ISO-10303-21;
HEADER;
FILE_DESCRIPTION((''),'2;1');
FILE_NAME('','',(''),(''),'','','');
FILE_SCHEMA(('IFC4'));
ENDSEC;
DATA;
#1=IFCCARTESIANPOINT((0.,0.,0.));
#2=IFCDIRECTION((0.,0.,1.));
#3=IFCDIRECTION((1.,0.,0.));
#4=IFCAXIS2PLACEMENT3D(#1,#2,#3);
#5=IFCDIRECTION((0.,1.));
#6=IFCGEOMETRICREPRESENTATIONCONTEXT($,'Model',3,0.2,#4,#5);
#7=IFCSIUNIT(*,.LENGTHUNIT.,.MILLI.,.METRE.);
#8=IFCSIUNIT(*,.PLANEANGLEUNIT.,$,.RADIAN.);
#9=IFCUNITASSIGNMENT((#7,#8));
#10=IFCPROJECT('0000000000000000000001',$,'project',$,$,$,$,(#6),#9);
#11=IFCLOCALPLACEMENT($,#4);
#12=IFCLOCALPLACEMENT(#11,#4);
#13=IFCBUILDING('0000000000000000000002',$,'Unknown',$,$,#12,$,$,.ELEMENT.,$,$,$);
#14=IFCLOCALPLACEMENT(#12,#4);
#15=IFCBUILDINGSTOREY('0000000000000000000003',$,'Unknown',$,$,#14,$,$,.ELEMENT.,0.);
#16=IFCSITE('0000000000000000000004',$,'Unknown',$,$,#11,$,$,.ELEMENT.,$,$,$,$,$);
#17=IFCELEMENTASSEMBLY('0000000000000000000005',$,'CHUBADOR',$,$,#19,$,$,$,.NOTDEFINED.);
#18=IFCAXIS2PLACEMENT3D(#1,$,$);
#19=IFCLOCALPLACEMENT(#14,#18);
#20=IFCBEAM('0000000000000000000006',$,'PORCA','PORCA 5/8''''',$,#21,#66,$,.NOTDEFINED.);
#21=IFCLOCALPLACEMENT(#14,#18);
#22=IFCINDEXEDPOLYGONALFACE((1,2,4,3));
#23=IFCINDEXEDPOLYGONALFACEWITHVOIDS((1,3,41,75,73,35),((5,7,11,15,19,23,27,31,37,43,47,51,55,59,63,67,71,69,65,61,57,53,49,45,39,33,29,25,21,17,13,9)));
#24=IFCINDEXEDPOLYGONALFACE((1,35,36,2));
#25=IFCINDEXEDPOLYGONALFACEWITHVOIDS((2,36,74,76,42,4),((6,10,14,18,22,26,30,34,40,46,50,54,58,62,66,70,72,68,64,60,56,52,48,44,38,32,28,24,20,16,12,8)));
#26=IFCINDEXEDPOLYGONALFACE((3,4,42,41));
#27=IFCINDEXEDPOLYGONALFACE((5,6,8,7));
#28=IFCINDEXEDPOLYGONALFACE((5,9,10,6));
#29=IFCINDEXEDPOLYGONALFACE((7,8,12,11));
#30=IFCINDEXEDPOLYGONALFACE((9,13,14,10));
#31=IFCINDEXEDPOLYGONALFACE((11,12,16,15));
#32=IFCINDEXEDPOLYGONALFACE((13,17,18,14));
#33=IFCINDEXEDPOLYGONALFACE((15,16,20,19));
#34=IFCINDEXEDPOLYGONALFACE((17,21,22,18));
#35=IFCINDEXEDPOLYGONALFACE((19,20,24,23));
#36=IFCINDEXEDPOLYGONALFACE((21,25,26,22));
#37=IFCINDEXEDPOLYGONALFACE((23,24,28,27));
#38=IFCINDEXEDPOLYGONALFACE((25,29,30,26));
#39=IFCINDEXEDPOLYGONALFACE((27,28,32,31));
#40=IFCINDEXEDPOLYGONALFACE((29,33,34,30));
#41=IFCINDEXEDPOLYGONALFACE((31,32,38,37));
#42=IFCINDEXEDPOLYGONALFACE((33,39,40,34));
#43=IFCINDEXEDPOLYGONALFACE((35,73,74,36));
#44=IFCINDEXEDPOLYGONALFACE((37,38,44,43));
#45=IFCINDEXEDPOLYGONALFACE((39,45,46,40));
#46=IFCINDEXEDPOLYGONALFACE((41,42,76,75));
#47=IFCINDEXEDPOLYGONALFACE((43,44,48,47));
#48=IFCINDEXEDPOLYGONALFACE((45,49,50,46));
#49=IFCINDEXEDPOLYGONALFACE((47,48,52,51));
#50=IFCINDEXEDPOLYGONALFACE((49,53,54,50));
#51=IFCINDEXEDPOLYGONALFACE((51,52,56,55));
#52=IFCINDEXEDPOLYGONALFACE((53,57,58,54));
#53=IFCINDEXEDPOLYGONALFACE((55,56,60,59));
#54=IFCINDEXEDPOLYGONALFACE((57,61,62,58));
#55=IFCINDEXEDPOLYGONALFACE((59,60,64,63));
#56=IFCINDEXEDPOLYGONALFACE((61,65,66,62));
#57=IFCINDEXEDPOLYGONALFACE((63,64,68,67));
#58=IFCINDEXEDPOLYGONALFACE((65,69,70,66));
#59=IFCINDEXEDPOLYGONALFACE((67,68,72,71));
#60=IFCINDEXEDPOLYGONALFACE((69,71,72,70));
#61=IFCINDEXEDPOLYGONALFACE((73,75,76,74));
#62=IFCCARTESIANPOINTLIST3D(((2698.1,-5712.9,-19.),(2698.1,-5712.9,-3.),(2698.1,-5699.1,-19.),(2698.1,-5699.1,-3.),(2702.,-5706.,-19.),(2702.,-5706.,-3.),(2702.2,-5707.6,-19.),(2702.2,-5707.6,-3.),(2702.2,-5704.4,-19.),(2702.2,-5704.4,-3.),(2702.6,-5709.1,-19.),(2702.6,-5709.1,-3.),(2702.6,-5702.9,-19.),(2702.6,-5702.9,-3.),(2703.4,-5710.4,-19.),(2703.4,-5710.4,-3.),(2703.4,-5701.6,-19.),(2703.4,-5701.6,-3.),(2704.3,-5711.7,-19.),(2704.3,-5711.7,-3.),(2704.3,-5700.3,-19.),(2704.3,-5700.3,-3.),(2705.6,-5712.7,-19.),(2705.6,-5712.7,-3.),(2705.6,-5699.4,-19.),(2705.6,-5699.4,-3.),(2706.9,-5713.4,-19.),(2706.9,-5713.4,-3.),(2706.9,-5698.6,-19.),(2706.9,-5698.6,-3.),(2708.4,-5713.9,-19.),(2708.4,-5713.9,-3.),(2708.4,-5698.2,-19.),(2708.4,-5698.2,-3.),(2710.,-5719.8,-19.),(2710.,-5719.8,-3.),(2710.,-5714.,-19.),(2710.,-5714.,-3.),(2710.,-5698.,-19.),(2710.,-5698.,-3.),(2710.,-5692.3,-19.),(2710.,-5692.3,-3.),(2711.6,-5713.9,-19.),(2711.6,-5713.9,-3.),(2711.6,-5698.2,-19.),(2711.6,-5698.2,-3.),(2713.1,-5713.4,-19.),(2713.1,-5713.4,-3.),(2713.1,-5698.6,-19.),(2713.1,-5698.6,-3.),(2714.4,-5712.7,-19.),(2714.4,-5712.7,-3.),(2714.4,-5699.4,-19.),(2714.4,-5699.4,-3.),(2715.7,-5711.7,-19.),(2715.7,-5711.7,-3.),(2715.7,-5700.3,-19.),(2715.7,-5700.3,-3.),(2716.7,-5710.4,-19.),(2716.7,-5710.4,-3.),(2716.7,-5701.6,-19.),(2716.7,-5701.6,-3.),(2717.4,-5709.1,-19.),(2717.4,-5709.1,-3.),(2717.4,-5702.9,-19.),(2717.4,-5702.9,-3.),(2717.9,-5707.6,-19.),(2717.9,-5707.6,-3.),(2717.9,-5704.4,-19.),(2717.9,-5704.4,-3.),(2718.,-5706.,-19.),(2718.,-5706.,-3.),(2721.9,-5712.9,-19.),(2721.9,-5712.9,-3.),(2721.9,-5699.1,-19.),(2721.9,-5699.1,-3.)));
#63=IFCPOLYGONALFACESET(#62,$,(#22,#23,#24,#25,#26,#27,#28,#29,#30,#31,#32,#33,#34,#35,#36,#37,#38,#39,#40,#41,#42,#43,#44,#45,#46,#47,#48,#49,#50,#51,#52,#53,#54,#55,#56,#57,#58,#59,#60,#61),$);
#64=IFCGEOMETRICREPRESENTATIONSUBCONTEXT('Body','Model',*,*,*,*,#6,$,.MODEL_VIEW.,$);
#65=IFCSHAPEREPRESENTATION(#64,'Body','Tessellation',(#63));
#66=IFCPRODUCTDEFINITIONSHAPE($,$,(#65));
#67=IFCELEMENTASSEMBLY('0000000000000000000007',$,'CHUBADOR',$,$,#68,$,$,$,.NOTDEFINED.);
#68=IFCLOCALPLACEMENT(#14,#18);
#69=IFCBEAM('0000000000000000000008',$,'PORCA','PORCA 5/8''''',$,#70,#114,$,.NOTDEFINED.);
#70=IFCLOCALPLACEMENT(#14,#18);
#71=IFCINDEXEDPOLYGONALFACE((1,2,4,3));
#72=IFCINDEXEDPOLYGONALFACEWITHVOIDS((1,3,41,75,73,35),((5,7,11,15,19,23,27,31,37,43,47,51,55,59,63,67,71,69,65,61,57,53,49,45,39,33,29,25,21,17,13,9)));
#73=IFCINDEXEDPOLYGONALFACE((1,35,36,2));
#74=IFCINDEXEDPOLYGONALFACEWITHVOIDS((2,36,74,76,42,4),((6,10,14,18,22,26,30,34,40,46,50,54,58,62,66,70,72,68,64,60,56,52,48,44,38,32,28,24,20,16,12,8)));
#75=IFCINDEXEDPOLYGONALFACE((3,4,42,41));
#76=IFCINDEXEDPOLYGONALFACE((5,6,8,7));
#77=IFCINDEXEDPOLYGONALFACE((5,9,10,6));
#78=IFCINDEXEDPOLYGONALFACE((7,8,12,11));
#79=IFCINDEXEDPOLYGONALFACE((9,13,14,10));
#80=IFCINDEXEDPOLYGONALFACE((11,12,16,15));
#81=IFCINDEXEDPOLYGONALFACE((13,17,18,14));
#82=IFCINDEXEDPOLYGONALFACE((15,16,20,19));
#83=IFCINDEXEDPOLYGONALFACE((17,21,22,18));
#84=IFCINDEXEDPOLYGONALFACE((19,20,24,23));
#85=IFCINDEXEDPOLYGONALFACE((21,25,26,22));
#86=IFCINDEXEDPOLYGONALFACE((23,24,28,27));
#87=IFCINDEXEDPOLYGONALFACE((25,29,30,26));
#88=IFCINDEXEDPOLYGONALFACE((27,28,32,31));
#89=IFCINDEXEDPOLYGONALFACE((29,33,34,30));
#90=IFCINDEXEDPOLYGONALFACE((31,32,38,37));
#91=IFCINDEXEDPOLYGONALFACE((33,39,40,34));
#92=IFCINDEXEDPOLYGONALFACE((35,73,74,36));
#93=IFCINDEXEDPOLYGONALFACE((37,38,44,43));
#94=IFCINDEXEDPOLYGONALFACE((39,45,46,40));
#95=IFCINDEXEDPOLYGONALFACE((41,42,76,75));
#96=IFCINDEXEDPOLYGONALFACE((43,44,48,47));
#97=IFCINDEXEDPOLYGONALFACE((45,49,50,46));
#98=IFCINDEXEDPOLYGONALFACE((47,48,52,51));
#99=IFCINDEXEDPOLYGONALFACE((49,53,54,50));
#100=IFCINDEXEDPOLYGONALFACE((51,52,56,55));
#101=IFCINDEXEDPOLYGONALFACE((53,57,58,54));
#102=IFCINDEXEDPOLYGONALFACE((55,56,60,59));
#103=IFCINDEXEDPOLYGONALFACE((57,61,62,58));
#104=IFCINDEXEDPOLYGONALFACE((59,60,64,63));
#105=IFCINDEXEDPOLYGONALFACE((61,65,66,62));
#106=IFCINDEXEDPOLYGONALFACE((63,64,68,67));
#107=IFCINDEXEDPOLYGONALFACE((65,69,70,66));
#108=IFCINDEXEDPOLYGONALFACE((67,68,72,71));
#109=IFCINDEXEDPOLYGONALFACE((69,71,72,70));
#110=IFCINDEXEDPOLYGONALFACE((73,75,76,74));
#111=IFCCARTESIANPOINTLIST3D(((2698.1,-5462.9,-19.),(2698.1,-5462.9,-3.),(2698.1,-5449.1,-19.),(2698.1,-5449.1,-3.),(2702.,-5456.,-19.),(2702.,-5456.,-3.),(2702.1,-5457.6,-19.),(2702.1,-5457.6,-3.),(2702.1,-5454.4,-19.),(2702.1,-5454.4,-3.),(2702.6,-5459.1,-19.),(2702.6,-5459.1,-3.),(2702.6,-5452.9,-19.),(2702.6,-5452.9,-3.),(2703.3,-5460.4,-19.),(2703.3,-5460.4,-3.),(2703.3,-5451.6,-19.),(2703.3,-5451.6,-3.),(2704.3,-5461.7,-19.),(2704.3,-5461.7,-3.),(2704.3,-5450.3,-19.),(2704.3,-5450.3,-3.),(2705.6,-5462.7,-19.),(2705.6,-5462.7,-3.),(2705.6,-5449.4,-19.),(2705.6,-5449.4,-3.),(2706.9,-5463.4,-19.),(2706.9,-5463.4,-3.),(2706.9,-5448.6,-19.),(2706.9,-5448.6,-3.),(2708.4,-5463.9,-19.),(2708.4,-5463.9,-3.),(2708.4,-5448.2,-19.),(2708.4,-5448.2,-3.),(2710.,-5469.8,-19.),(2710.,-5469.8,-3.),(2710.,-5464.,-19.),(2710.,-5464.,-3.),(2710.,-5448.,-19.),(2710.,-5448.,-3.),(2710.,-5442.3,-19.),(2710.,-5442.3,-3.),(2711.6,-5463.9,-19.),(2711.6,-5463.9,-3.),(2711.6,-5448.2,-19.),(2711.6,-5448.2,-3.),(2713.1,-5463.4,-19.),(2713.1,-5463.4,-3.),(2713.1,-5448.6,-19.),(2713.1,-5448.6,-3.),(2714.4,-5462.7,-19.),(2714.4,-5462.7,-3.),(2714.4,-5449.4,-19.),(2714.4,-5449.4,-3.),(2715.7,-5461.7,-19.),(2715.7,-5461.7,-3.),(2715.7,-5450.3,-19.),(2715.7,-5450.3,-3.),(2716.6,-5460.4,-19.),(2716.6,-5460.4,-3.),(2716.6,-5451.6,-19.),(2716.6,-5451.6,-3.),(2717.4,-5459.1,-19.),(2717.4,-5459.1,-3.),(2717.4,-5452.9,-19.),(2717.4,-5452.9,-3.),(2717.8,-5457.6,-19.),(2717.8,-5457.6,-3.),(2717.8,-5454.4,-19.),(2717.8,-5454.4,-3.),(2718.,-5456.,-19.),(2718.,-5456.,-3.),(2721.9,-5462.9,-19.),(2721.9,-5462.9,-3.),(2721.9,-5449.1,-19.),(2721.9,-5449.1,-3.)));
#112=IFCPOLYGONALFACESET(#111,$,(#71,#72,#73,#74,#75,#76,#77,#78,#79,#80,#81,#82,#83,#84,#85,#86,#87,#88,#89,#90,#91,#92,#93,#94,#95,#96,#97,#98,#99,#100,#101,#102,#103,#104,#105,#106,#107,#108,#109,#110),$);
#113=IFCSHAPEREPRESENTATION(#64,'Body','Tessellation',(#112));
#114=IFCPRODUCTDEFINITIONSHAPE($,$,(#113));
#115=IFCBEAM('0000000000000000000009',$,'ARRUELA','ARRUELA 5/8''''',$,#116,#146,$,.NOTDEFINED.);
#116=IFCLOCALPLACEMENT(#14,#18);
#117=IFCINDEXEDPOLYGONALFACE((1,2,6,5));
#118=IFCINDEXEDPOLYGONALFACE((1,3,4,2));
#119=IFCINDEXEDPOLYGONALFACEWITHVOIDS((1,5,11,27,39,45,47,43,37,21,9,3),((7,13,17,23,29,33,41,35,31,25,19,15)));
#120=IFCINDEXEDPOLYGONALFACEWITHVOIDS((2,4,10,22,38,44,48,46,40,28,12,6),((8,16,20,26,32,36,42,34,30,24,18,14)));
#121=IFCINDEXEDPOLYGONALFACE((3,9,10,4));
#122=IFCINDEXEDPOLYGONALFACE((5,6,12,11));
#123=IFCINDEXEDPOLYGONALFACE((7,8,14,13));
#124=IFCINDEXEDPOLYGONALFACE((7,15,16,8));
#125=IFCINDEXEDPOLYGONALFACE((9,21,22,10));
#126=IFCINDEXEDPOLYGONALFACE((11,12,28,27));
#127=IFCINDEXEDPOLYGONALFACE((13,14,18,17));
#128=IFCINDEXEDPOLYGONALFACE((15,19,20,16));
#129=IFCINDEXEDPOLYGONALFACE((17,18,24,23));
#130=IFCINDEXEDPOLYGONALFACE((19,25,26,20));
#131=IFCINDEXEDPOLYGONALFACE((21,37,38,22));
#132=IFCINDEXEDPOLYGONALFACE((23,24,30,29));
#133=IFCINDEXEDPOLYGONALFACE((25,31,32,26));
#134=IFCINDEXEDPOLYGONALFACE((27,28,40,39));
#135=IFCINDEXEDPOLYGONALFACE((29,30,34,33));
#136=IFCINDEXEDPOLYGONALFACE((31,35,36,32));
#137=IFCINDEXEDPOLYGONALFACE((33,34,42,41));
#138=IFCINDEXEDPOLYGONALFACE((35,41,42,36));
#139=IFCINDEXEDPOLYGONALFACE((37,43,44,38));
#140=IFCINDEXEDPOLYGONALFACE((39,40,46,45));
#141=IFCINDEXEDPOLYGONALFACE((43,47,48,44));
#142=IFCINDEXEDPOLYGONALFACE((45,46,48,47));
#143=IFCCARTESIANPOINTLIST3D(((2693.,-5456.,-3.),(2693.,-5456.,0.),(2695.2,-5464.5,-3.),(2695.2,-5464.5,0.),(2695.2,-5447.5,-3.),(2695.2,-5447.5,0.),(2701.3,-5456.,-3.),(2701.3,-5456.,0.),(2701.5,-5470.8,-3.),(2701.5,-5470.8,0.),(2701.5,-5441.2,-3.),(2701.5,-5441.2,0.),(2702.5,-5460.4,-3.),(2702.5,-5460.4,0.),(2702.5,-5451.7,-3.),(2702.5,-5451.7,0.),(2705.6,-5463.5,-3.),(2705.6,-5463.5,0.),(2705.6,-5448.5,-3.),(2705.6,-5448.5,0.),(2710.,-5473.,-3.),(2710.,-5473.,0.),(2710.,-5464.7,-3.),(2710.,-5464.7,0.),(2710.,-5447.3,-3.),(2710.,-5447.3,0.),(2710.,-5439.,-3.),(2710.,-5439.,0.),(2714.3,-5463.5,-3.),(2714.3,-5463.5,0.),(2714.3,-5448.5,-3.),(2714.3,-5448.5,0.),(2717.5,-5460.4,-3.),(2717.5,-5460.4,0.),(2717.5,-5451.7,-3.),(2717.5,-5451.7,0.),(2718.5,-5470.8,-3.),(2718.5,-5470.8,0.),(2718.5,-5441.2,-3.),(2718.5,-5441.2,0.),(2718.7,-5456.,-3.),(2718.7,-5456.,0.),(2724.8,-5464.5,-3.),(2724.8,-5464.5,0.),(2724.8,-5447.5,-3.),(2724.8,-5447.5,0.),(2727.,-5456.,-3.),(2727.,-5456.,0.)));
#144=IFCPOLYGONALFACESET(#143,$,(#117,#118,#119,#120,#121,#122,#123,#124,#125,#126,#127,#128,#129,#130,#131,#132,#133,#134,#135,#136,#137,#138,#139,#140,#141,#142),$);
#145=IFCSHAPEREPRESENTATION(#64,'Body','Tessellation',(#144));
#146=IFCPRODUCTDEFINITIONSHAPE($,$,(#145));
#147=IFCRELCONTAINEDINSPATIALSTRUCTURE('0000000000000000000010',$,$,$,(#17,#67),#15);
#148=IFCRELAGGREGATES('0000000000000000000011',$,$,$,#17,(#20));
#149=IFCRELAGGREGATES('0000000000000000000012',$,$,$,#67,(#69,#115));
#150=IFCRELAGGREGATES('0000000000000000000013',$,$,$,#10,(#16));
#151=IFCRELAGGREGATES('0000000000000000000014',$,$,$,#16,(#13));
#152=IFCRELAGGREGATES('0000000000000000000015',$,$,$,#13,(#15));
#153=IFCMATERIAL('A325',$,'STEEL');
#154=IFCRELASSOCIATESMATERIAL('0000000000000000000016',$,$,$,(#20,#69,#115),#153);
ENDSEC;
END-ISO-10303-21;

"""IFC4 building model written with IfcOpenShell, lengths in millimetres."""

from ifc_helpers import new_model, si_unit, direction, frame, origin_with_axes, place, context, subcontext, project, spatial, line, indexed_curve, outline, extrude, material, element, aggregate, save


model = new_model("IFC4")

# Units and contexts
model_context = context("Model", 3, precision=0.2, world=origin_with_axes(), true_north=direction((0.0, 1.0)))
body_context = subcontext(model_context, "Body", "Model", "MODEL_VIEW")
ifc_project = project(units=[si_unit("LENGTHUNIT", "METRE", prefix="MILLI"), si_unit("PLANEANGLEUNIT", "RADIAN")], contexts=[model_context])

# Site, building, storey
site_placement = place(None, origin_with_axes())
site = spatial("IfcSite", under=ifc_project, at=site_placement, Name="Unknown", CompositionType="ELEMENT")
building_placement = place(site_placement, origin_with_axes())
building = spatial("IfcBuilding", under=site, at=building_placement, Name="Unknown", CompositionType="ELEMENT")
storey_placement = place(building_placement, origin_with_axes())
storey = spatial("IfcBuildingStorey", under=building, at=storey_placement, Name="Unknown", CompositionType="ELEMENT", Elevation=0.0)

# Shared definitions
ifc_material_1 = material(Name="A325", Category="STEEL")

# Element assemblies, beams
assembly_1_placement = place(storey_placement, frame((2710.0, -5706.0, -52.1), z_axis=(-1.0, 0.0, 0.0), x_axis=(0.0, 0.0, -1.0)))
assembly_1 = element("IfcElementAssembly", 1, at=assembly_1_placement, inside=storey, Name="CHUBADOR", PredefinedType="NOTDEFINED")
beam_1_placement = place(assembly_1_placement, frame((-49.1, 0.0, 0.0), z_axis=(0.0, 0.0, 1.0), x_axis=(1.0, 0.0, 0.0)))
beam_1 = element("IfcBeam", 2, at=beam_1_placement, material=ifc_material_1, Name="PORCA", Description="PORCA 5/8''", PredefinedType="NOTDEFINED", context=body_context, shape_type="SolidModel", body=[
    extrude(outline(indexed_curve([(0.0, 13.8), (-11.9, 6.9), (-11.9, -6.9), (0.0, -13.8), (11.9, -6.9), (11.9, 6.9)], segments=[line(1, 2, 3, 4, 5, 6, 1)]), holes=[indexed_curve([(7.8, 1.6), (8.0, 0.0), (7.8, -1.6), (7.4, -3.1), (6.7, -4.4), (5.7, -5.7), (4.4, -6.7), (3.1, -7.4), (1.6, -7.8), (0.0, -8.0), (-1.6, -7.8), (-3.1, -7.4), (-4.4, -6.7), (-5.7, -5.7), (-6.7, -4.4), (-7.4, -3.1), (-7.8, -1.6), (-8.0, 0.0), (-7.8, 1.6), (-7.4, 3.1), (-6.7, 4.4), (-5.7, 5.7), (-4.4, 6.7), (-3.1, 7.4), (-1.6, 7.8), (0.0, 8.0), (1.6, 7.8), (3.1, 7.4), (4.4, 6.7), (5.7, 5.7), (6.7, 4.4), (7.4, 3.1)], segments=[line(1, 2, 3, 4, 5, 6, 7, 8, 9, 10, 11, 12, 13, 14, 15, 16, 17, 18, 19, 20, 21, 22, 23, 24, 25, 26, 27, 28, 29, 30, 31, 32, 1)])]), frame((0.0, 0.0, 0.0), z_axis=(-1.0, 0.0, 0.0), x_axis=(0.0, 0.0, 1.0)), (0.0, 0.0, -1.0), 16.0),
])
aggregate(assembly_1, [beam_1])
assembly_2_placement = place(storey_placement, frame((2710.0, -5456.0, -52.1), z_axis=(-1.0, 0.0, 0.0), x_axis=(0.0, 0.0, -1.0)))
assembly_2 = element("IfcElementAssembly", 3, at=assembly_2_placement, inside=storey, Name="CHUBADOR", PredefinedType="NOTDEFINED")
beam_2_placement = place(assembly_2_placement, frame((-49.1, 0.0, 0.0), z_axis=(0.0, 0.0, 1.0), x_axis=(1.0, 0.0, 0.0)))
beam_2 = element("IfcBeam", 4, at=beam_2_placement, material=ifc_material_1, Name="PORCA", Description="PORCA 5/8''", PredefinedType="NOTDEFINED", context=body_context, shape_type="SolidModel", body=[
    extrude(outline(indexed_curve([(0.0, 13.8), (-11.9, 6.9), (-11.9, -6.9), (0.0, -13.8), (11.9, -6.9), (11.9, 6.9)], segments=[line(1, 2, 3, 4, 5, 6, 1)]), holes=[indexed_curve([(7.8, 1.6), (8.0, 0.0), (7.8, -1.6), (7.4, -3.1), (6.7, -4.4), (5.7, -5.7), (4.4, -6.7), (3.1, -7.4), (1.6, -7.8), (0.0, -8.0), (-1.6, -7.8), (-3.1, -7.4), (-4.4, -6.7), (-5.7, -5.7), (-6.7, -4.4), (-7.4, -3.1), (-7.8, -1.6), (-8.0, 0.0), (-7.8, 1.6), (-7.4, 3.1), (-6.7, 4.4), (-5.7, 5.7), (-4.4, 6.7), (-3.1, 7.4), (-1.6, 7.8), (0.0, 8.0), (1.6, 7.8), (3.1, 7.4), (4.4, 6.7), (5.7, 5.7), (6.7, 4.4), (7.4, 3.1)], segments=[line(1, 2, 3, 4, 5, 6, 7, 8, 9, 10, 11, 12, 13, 14, 15, 16, 17, 18, 19, 20, 21, 22, 23, 24, 25, 26, 27, 28, 29, 30, 31, 32, 1)])]), frame((0.0, 0.0, 0.0), z_axis=(-1.0, 0.0, 0.0), x_axis=(0.0, 0.0, 1.0)), (0.0, 0.0, -1.0), 16.0),
])
beam_3_placement = place(assembly_2_placement, frame((-52.1, 0.0, 0.0), z_axis=(0.0, 0.0, 1.0), x_axis=(1.0, 0.0, 0.0)))
beam_3 = element("IfcBeam", 5, at=beam_3_placement, material=ifc_material_1, Name="ARRUELA", Description="ARRUELA 5/8''", PredefinedType="NOTDEFINED", context=body_context, shape_type="SolidModel", body=[
    extrude(outline(indexed_curve([(17.0, 0.0), (14.8, 8.5), (8.5, 14.8), (0.0, 17.0), (-8.5, 14.8), (-14.8, 8.5), (-17.0, 0.0), (-14.8, -8.5), (-8.5, -14.8), (0.0, -17.0), (8.5, -14.8), (14.8, -8.5)], segments=[line(1, 2, 3, 4, 5, 6, 7, 8, 9, 10, 11, 12, 1)]), holes=[indexed_curve([(8.7, 0.0), (7.5, -4.3), (4.3, -7.5), (0.0, -8.7), (-4.3, -7.5), (-7.5, -4.3), (-8.7, 0.0), (-7.5, 4.3), (-4.3, 7.5), (0.0, 8.7), (4.3, 7.5), (7.5, 4.3)], segments=[line(1, 2, 3, 4, 5, 6, 7, 8, 9, 10, 11, 12, 1)])]), frame((0.0, 0.0, 0.0), z_axis=(-1.0, 0.0, 0.0), x_axis=(0.0, 0.0, 1.0)), (0.0, 0.0, -1.0), 3.0),
])
aggregate(assembly_2, [beam_2, beam_3])

save(model, "model.ifc")
